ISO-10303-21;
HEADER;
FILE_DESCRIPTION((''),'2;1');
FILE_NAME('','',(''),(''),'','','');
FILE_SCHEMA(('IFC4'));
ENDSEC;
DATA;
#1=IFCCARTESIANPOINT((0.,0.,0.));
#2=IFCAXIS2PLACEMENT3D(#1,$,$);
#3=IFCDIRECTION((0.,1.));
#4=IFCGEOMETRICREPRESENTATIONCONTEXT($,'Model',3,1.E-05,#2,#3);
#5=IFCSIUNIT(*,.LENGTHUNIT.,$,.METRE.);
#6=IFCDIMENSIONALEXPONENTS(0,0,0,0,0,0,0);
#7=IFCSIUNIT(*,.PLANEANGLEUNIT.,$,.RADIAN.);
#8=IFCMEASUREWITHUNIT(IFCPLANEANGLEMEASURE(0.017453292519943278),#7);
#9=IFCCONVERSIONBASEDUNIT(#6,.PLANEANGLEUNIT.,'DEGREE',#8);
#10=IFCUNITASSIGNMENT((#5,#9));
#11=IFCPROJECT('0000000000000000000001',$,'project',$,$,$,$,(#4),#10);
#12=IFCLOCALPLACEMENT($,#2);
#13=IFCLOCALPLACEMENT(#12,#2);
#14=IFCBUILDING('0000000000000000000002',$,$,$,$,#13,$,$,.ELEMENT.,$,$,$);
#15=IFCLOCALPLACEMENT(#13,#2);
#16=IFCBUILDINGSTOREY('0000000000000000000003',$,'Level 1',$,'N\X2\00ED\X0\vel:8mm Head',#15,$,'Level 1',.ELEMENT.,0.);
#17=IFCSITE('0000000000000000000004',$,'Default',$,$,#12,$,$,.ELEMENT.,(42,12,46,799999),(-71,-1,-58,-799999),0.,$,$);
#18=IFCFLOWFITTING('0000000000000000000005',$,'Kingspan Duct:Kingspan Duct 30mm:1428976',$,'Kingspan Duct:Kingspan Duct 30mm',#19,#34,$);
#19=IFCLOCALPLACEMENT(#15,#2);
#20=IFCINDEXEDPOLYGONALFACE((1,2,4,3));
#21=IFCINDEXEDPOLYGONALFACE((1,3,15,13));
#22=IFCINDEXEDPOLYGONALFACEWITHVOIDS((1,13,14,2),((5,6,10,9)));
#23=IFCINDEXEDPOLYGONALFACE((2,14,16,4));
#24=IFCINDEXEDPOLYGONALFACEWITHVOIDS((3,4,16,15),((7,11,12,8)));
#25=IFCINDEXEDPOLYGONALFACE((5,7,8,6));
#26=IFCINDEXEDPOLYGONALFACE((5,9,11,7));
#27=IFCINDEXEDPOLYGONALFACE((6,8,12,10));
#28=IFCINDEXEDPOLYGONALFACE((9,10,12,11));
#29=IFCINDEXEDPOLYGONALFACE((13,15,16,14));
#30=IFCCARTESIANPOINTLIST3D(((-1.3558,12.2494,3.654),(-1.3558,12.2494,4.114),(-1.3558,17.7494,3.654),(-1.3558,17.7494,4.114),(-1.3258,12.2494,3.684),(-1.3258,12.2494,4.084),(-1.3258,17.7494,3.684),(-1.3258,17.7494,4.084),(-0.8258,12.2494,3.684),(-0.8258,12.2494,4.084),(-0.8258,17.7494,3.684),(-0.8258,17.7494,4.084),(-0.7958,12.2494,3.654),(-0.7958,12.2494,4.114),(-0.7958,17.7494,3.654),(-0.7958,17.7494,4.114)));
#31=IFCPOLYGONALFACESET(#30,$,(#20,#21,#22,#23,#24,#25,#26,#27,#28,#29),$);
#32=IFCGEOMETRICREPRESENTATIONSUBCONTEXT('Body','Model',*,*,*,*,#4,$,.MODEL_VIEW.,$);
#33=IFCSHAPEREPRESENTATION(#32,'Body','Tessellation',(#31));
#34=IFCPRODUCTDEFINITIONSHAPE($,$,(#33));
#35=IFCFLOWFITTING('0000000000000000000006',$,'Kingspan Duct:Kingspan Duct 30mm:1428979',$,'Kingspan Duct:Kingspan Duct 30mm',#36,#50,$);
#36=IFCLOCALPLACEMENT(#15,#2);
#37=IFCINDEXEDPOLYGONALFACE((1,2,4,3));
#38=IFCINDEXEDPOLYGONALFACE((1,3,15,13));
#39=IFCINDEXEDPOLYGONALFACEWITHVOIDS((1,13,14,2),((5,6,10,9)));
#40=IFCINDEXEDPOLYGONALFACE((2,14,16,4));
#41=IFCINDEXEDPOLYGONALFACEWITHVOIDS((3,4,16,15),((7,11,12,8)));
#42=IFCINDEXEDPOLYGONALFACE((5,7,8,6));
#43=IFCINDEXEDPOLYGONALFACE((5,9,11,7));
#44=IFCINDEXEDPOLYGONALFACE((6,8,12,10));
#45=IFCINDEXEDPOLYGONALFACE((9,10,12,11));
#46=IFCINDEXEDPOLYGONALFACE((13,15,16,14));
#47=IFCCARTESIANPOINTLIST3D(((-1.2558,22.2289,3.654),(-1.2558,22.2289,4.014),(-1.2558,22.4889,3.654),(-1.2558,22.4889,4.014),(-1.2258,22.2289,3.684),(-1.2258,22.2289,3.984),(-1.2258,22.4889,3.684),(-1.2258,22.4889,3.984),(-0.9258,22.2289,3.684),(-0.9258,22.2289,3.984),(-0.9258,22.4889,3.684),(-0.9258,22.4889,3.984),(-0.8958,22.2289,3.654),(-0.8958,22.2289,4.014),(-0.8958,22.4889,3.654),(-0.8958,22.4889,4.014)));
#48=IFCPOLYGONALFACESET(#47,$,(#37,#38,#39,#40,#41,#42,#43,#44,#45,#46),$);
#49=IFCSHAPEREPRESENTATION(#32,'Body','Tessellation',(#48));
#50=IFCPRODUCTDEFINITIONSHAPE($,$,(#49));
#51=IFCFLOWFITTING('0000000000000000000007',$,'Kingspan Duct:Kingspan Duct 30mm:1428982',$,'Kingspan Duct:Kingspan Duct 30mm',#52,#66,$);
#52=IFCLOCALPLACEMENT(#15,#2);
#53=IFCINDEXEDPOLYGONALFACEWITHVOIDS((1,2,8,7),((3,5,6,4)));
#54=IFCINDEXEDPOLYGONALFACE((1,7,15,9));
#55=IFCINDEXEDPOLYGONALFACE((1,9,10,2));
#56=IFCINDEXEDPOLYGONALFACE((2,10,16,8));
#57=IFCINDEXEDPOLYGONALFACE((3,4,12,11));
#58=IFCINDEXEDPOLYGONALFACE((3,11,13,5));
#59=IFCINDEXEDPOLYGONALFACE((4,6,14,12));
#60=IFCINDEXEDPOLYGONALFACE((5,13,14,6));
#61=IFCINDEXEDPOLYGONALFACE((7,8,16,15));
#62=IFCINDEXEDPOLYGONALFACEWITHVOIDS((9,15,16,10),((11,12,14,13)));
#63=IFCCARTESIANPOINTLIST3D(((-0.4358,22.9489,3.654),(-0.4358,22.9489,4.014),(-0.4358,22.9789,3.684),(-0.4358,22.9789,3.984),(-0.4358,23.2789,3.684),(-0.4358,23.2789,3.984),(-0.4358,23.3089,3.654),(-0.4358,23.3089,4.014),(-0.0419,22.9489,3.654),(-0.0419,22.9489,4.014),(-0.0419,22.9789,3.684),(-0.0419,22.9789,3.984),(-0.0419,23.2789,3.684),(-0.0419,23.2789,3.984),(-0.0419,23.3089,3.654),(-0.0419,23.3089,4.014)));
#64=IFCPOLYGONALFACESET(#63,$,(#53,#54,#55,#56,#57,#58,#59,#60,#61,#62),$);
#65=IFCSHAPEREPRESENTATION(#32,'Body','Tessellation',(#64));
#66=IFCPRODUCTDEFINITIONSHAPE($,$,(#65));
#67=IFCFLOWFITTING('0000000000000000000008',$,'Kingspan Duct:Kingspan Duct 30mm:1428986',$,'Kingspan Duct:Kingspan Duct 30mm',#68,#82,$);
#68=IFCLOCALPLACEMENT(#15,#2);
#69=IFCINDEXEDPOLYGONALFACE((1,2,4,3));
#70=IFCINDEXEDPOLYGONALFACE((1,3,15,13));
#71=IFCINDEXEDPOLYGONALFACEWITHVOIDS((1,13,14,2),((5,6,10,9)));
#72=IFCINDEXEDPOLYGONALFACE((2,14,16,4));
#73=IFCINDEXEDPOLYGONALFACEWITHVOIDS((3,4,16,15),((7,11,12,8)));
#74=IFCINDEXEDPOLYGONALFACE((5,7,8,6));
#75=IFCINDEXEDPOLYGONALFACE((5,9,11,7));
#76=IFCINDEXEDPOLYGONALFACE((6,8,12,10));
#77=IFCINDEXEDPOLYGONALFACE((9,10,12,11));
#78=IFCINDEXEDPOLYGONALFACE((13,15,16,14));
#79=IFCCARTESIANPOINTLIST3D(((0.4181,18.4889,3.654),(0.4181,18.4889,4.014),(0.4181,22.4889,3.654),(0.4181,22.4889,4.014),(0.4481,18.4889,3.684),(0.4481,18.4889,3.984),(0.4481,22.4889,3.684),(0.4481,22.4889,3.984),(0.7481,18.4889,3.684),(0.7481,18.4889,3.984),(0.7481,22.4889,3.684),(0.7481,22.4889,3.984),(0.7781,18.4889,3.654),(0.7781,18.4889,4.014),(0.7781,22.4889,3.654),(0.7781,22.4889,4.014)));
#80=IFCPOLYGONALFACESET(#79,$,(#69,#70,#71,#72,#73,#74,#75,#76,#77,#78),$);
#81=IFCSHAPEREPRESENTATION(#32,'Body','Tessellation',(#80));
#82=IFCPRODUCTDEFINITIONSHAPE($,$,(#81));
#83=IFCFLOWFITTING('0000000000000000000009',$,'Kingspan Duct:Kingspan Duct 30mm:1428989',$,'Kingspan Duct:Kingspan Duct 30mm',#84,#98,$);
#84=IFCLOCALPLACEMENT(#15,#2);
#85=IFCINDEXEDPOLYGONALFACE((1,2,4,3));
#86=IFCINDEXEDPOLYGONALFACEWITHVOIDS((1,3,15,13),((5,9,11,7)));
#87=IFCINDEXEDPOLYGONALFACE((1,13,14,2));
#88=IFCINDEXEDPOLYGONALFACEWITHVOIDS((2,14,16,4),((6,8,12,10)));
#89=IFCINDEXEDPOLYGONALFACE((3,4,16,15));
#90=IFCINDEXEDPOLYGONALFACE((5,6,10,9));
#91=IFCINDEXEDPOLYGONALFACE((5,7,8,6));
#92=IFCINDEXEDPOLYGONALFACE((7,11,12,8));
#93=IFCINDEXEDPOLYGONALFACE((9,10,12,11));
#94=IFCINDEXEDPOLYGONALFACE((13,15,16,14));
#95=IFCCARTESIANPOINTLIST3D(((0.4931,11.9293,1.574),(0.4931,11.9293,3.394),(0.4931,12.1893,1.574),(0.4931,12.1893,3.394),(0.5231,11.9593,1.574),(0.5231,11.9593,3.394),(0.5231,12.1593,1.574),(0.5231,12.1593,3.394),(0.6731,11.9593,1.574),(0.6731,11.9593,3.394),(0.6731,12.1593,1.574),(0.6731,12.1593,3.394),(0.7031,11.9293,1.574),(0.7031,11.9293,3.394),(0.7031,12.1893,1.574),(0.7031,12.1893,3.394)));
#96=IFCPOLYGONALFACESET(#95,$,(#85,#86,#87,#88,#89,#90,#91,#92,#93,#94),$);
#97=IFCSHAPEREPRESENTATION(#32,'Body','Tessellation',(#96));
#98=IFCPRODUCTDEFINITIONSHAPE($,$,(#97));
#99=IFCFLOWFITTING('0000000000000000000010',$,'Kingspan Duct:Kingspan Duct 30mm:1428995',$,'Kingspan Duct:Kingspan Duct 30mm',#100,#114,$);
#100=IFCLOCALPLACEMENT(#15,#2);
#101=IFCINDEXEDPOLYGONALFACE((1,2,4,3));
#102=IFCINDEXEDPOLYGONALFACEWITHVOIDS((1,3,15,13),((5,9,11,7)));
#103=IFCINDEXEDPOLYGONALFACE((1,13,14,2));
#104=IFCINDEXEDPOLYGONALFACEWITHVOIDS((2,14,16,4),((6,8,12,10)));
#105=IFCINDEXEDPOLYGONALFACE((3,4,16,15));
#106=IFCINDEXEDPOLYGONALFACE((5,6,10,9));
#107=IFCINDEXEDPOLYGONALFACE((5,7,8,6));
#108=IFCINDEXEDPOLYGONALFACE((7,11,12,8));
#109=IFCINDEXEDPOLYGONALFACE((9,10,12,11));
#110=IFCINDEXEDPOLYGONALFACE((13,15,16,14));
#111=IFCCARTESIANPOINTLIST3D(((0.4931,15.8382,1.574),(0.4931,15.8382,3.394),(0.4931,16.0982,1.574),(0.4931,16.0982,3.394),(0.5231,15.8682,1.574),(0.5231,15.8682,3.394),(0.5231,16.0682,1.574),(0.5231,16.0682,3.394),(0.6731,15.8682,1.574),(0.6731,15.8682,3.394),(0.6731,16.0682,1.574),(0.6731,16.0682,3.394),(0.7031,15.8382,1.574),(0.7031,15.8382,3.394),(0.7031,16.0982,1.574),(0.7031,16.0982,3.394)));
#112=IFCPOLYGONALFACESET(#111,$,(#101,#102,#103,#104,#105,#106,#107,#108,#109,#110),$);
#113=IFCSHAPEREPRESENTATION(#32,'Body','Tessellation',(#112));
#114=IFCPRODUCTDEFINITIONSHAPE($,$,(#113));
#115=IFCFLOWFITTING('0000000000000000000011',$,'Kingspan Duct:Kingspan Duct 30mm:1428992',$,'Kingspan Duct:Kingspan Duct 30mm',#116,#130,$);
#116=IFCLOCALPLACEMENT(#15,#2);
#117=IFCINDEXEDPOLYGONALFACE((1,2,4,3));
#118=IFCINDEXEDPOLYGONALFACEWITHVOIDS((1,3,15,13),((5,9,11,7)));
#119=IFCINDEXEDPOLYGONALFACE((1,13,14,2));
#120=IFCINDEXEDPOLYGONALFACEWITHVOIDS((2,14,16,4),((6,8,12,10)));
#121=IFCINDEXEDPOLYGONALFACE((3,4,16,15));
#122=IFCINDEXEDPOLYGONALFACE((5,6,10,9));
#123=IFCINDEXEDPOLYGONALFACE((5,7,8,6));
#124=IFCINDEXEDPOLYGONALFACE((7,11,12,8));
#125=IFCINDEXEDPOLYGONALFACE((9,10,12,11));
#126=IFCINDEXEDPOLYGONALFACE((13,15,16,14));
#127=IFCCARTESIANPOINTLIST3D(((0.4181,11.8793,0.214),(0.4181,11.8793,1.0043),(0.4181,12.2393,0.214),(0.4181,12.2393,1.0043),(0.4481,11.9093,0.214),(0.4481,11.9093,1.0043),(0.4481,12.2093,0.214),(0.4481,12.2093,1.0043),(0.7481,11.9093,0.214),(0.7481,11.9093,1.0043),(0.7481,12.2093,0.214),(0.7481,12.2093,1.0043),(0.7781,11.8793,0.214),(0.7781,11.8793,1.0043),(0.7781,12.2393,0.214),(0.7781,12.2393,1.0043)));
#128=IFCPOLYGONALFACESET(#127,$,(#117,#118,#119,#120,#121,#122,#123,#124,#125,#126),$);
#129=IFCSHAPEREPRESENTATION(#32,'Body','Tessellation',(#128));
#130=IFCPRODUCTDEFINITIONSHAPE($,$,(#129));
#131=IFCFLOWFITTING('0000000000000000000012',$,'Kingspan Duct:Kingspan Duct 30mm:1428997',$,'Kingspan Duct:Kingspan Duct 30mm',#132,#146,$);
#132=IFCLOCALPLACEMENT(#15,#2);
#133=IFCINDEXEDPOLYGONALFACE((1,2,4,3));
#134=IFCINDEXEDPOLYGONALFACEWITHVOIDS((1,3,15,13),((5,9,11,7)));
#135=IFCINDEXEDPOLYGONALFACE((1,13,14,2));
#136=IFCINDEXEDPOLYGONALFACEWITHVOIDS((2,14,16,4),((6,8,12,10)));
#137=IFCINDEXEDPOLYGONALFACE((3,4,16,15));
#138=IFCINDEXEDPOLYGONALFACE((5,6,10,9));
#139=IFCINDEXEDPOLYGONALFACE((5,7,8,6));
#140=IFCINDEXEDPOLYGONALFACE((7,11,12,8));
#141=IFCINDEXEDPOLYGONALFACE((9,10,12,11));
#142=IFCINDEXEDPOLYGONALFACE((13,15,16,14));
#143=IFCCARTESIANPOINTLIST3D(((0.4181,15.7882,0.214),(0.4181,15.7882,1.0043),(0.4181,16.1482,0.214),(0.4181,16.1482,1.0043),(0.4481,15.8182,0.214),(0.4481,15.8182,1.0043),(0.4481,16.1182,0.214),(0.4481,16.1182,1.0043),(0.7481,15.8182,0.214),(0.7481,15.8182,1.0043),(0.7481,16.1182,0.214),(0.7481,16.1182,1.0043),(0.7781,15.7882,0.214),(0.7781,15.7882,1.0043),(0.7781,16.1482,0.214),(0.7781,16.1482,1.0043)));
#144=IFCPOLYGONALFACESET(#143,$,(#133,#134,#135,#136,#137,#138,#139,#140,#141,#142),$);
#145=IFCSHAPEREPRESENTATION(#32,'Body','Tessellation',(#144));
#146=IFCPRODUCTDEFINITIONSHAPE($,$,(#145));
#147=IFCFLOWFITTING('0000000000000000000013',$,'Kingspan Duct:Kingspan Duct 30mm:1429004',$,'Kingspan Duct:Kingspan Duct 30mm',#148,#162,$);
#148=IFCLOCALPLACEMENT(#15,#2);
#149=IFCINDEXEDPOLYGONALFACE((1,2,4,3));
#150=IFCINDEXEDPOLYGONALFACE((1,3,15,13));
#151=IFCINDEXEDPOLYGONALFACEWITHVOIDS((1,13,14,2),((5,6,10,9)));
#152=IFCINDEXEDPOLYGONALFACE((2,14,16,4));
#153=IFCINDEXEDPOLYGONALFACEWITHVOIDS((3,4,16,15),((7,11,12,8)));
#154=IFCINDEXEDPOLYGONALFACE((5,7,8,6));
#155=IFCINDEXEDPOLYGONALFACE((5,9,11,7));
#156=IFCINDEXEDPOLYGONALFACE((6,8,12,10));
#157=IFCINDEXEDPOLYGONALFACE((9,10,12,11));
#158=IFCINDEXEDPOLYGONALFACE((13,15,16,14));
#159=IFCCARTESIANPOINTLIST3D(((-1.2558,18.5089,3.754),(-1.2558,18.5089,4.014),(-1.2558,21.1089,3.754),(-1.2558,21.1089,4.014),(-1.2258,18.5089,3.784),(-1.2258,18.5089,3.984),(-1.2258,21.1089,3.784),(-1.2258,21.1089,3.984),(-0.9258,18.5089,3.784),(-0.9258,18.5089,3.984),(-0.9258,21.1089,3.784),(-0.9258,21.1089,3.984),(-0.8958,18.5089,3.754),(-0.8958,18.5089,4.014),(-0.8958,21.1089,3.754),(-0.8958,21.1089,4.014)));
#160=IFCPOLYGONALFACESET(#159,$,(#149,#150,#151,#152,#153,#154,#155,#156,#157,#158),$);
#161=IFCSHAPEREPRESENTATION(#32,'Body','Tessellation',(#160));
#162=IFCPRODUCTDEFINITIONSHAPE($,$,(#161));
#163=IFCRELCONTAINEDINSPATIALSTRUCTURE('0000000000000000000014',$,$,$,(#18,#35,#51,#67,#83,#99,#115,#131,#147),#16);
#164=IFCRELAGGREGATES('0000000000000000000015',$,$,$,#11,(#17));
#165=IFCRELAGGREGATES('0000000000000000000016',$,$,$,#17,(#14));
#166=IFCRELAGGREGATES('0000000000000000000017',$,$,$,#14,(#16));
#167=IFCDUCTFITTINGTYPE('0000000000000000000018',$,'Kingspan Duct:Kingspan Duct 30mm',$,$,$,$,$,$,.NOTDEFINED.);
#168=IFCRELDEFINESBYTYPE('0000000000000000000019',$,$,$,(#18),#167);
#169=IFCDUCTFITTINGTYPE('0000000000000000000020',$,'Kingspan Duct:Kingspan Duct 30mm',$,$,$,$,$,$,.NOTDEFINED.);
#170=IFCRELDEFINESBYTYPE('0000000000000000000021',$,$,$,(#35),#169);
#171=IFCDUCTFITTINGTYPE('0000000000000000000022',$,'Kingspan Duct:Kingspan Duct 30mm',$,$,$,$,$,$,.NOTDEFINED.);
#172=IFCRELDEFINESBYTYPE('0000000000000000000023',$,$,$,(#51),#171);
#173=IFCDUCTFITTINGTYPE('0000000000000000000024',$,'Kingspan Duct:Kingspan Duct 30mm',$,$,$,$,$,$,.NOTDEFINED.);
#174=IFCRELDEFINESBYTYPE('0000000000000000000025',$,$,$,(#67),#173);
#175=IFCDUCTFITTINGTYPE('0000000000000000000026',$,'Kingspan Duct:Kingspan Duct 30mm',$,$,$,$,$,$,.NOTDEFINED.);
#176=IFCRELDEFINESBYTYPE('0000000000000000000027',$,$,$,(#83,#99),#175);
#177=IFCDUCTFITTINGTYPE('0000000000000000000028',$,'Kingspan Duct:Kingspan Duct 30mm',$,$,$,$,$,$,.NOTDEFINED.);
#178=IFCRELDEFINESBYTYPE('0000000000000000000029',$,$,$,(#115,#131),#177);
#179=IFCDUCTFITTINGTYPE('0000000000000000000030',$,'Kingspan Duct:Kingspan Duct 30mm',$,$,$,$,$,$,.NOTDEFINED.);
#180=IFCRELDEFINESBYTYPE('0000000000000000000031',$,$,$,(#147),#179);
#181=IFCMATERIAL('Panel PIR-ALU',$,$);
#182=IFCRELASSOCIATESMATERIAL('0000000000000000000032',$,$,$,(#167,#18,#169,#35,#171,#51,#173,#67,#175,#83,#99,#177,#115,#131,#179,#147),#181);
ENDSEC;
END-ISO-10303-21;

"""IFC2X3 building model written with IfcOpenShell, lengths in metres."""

from ifc_helpers import new_model, entity, si_unit, converted_unit, direction, frame, origin, place, context, subcontext, project, spatial, polyline, outline, extrude, source, transform, mapped, material, type_object, type_shapes, element, save


model = new_model("IFC2X3")

# Units and contexts
model_context = context("Model", 3, precision=1e-05, world=origin(), true_north=direction((0.0, 1.0)))
body_context = subcontext(model_context, "Body", "Model", "MODEL_VIEW")
ifc_project = project(units=[si_unit("LENGTHUNIT", "METRE"), converted_unit("PLANEANGLEUNIT", "DEGREE", entity("IfcPlaneAngleMeasure", 0.017453292519943278), si_unit("PLANEANGLEUNIT", "RADIAN"), dimensions=[0, 0, 0, 0, 0, 0, 0])], contexts=[model_context])

# Site, building, storey
site_placement = place(None, origin())
site = spatial("IfcSite", under=ifc_project, at=site_placement, Name="Default", CompositionType="ELEMENT", RefLatitude=(42, 12, 46, 799999), RefLongitude=(-71, -1, -58, -799999), RefElevation=0.0)
building_placement = place(site_placement, origin())
building = spatial("IfcBuilding", under=site, at=building_placement, CompositionType="ELEMENT")
storey_placement = place(building_placement, origin())
storey = spatial("IfcBuildingStorey", under=building, at=storey_placement, Name="Level 1", ObjectType="Nível:8mm Head", LongName="Level 1", CompositionType="ELEMENT", Elevation=0.0)

# Flow fittings
ifc_material = material(Name="Panel PIR-ALU")
duct_fitting_type_1 = type_object("IfcDuctFittingType", Name="Kingspan Duct:Kingspan Duct 30mm", PredefinedType="NOTDEFINED", material=ifc_material)
shared_shape_1 = source(origin(), body_context, "Body", "SweptSolid", [
    extrude(outline(polyline([(-0.28, -0.23), (0.28, -0.23), (0.28, 0.23), (-0.28, 0.23), (-0.28, -0.23)]), holes=[polyline([(-0.25, -0.2), (-0.25, 0.2), (0.25, 0.2), (0.25, -0.2), (-0.25, -0.2)])]), frame((0.0, 0.0, -0.2), z_axis=(1.0, 0.0, 0.0), x_axis=(0.0, -1.0, 0.0)), (0.0, 0.0, 1.0), 5.5),
])
type_shapes(duct_fitting_type_1, [shared_shape_1])
flow_fitting_1_placement = place(storey_placement, frame((-1.0758, 17.7494, 3.684), z_axis=(0.0, 0.0, -1.0), x_axis=(0.0, -1.0, 0.0)))
element("IfcFlowFitting", 1, at=flow_fitting_1_placement, inside=storey, type_object=duct_fitting_type_1, material=ifc_material, Name="Kingspan Duct:Kingspan Duct 30mm:1428976", ObjectType="Kingspan Duct:Kingspan Duct 30mm", context=body_context, shape_type="MappedRepresentation", body=[
    mapped(shared_shape_1, transform((0.0, 0.0, 0.0), scale=1.0)),
])
duct_fitting_type_2 = type_object("IfcDuctFittingType", Name="Kingspan Duct:Kingspan Duct 30mm", PredefinedType="NOTDEFINED", material=ifc_material)
shared_shape_2 = source(origin(), body_context, "Body", "SweptSolid", [
    extrude(outline(polyline([(-0.18, -0.18), (0.18, -0.18), (0.18, 0.18), (-0.18, 0.18), (-0.18, -0.18)]), holes=[polyline([(-0.15, -0.15), (-0.15, 0.15), (0.15, 0.15), (0.15, -0.15), (-0.15, -0.15)])]), frame((0.0, 0.0, -0.15), z_axis=(1.0, 0.0, 0.0), x_axis=(0.0, -1.0, 0.0)), (0.0, 0.0, 1.0), 0.26),
])
type_shapes(duct_fitting_type_2, [shared_shape_2])
flow_fitting_2_placement = place(storey_placement, frame((-1.0758, 22.2289, 3.684), z_axis=(0.0, 0.0, -1.0), x_axis=(0.0, 1.0, 0.0)))
element("IfcFlowFitting", 2, at=flow_fitting_2_placement, inside=storey, type_object=duct_fitting_type_2, material=ifc_material, Name="Kingspan Duct:Kingspan Duct 30mm:1428979", ObjectType="Kingspan Duct:Kingspan Duct 30mm", context=body_context, shape_type="MappedRepresentation", body=[
    mapped(shared_shape_2, transform((0.0, 0.0, 0.0), scale=1.0)),
])
duct_fitting_type_3 = type_object("IfcDuctFittingType", Name="Kingspan Duct:Kingspan Duct 30mm", PredefinedType="NOTDEFINED", material=ifc_material)
shared_shape_3 = source(origin(), body_context, "Body", "SweptSolid", [
    extrude(outline(polyline([(-0.18, -0.18), (0.18, -0.18), (0.18, 0.18), (-0.18, 0.18), (-0.18, -0.18)]), holes=[polyline([(-0.15, -0.15), (-0.15, 0.15), (0.15, 0.15), (0.15, -0.15), (-0.15, -0.15)])]), frame((0.0, 0.0, -0.15), z_axis=(1.0, 0.0, 0.0), x_axis=(0.0, -1.0, 0.0)), (0.0, 0.0, 1.0), 0.3939),
])
type_shapes(duct_fitting_type_3, [shared_shape_3])
flow_fitting_3_placement = place(storey_placement, frame((-0.4358, 23.1289, 3.684), z_axis=(0.0, 0.0, -1.0), x_axis=(1.0, 0.0, 0.0)))
element("IfcFlowFitting", 3, at=flow_fitting_3_placement, inside=storey, type_object=duct_fitting_type_3, material=ifc_material, Name="Kingspan Duct:Kingspan Duct 30mm:1428982", ObjectType="Kingspan Duct:Kingspan Duct 30mm", context=body_context, shape_type="MappedRepresentation", body=[
    mapped(shared_shape_3, transform((0.0, 0.0, 0.0), scale=1.0)),
])
duct_fitting_type_4 = type_object("IfcDuctFittingType", Name="Kingspan Duct:Kingspan Duct 30mm", PredefinedType="NOTDEFINED", material=ifc_material)
shared_shape_4 = source(origin(), body_context, "Body", "SweptSolid", [
    extrude(outline(polyline([(-0.18, -0.18), (0.18, -0.18), (0.18, 0.18), (-0.18, 0.18), (-0.18, -0.18)]), holes=[polyline([(-0.15, -0.15), (-0.15, 0.15), (0.15, 0.15), (0.15, -0.15), (-0.15, -0.15)])]), frame((0.0, 0.0, -0.15), z_axis=(1.0, 0.0, 0.0), x_axis=(0.0, -1.0, 0.0)), (0.0, 0.0, 1.0), 4.0),
])
type_shapes(duct_fitting_type_4, [shared_shape_4])
flow_fitting_4_placement = place(storey_placement, frame((0.5981, 22.4889, 3.684), z_axis=(0.0, 0.0, -1.0), x_axis=(0.0, -1.0, 0.0)))
element("IfcFlowFitting", 4, at=flow_fitting_4_placement, inside=storey, type_object=duct_fitting_type_4, material=ifc_material, Name="Kingspan Duct:Kingspan Duct 30mm:1428986", ObjectType="Kingspan Duct:Kingspan Duct 30mm", context=body_context, shape_type="MappedRepresentation", body=[
    mapped(shared_shape_4, transform((0.0, 0.0, 0.0), scale=1.0)),
])
duct_fitting_type_5 = type_object("IfcDuctFittingType", Name="Kingspan Duct:Kingspan Duct 30mm", PredefinedType="NOTDEFINED", material=ifc_material)
shared_shape_5 = source(origin(), body_context, "Body", "SweptSolid", [
    extrude(outline(polyline([(-0.105, -0.13), (0.105, -0.13), (0.105, 0.13), (-0.105, 0.13), (-0.105, -0.13)]), holes=[polyline([(-0.075, -0.1), (-0.075, 0.1), (0.075, 0.1), (0.075, -0.1), (-0.075, -0.1)])]), frame((0.0, 0.0, -0.1), z_axis=(1.0, 0.0, 0.0), x_axis=(0.0, -1.0, 0.0)), (0.0, 0.0, 1.0), 1.82),
])
type_shapes(duct_fitting_type_5, [shared_shape_5])
for number, where, z_axis, x_axis, name in (
    (5, (0.5981, 11.9593, 3.394), (0.0, -1.0, 0.0), (0.0, 0.0, -1.0), "Kingspan Duct:Kingspan Duct 30mm:1428989"),
    (6, (0.5981, 15.8682, 3.394), (0.0, -1.0, 0.0), (0.0, 0.0, -1.0), "Kingspan Duct:Kingspan Duct 30mm:1428995"),
):
    element("IfcFlowFitting", number, at=place(storey_placement, frame(where, z_axis=z_axis, x_axis=x_axis)), inside=storey, type_object=duct_fitting_type_5, material=ifc_material, Name=name, ObjectType="Kingspan Duct:Kingspan Duct 30mm", context=body_context, shape_type="MappedRepresentation", body=[
        mapped(shared_shape_5, transform((0.0, 0.0, 0.0), scale=1.0)),
    ])
duct_fitting_type_6 = type_object("IfcDuctFittingType", Name="Kingspan Duct:Kingspan Duct 30mm", PredefinedType="NOTDEFINED", material=ifc_material)
shared_shape_6 = source(origin(), body_context, "Body", "SweptSolid", [
    extrude(outline(polyline([(-0.18, -0.18), (0.18, -0.18), (0.18, 0.18), (-0.18, 0.18), (-0.18, -0.18)]), holes=[polyline([(-0.15, -0.15), (-0.15, 0.15), (0.15, 0.15), (0.15, -0.15), (-0.15, -0.15)])]), frame((0.0, 0.0, -0.15), z_axis=(1.0, 0.0, 0.0), x_axis=(0.0, -1.0, 0.0)), (0.0, 0.0, 1.0), 0.7903),
])
type_shapes(duct_fitting_type_6, [shared_shape_6])
for number, where, z_axis, x_axis, name in (
    (7, (0.5981, 11.9093, 1.0043), (0.0, -1.0, 0.0), (0.0, 0.0, -1.0), "Kingspan Duct:Kingspan Duct 30mm:1428992"),
    (8, (0.5981, 16.1182, 1.0043), (0.0, 1.0, 0.0), (0.0, 0.0, -1.0), "Kingspan Duct:Kingspan Duct 30mm:1428997"),
):
    element("IfcFlowFitting", number, at=place(storey_placement, frame(where, z_axis=z_axis, x_axis=x_axis)), inside=storey, type_object=duct_fitting_type_6, material=ifc_material, Name=name, ObjectType="Kingspan Duct:Kingspan Duct 30mm", context=body_context, shape_type="MappedRepresentation", body=[
        mapped(shared_shape_6, transform((0.0, 0.0, 0.0), scale=1.0)),
    ])
duct_fitting_type_7 = type_object("IfcDuctFittingType", Name="Kingspan Duct:Kingspan Duct 30mm", PredefinedType="NOTDEFINED", material=ifc_material)
shared_shape_7 = source(origin(), body_context, "Body", "SweptSolid", [
    extrude(outline(polyline([(-0.18, -0.13), (0.18, -0.13), (0.18, 0.13), (-0.18, 0.13), (-0.18, -0.13)]), holes=[polyline([(-0.15, -0.1), (-0.15, 0.1), (0.15, 0.1), (0.15, -0.1), (-0.15, -0.1)])]), frame((0.0, 0.0, -0.1), z_axis=(1.0, 0.0, 0.0), x_axis=(0.0, -1.0, 0.0)), (0.0, 0.0, 1.0), 2.6),
])
type_shapes(duct_fitting_type_7, [shared_shape_7])
flow_fitting_5_placement = place(storey_placement, frame((-1.0758, 21.1089, 3.784), z_axis=(0.0, 0.0, -1.0), x_axis=(0.0, -1.0, 0.0)))
element("IfcFlowFitting", 9, at=flow_fitting_5_placement, inside=storey, type_object=duct_fitting_type_7, material=ifc_material, Name="Kingspan Duct:Kingspan Duct 30mm:1429004", ObjectType="Kingspan Duct:Kingspan Duct 30mm", context=body_context, shape_type="MappedRepresentation", body=[
    mapped(shared_shape_7, transform((0.0, 0.0, 0.0), scale=1.0)),
])

save(model, "model.ifc")
